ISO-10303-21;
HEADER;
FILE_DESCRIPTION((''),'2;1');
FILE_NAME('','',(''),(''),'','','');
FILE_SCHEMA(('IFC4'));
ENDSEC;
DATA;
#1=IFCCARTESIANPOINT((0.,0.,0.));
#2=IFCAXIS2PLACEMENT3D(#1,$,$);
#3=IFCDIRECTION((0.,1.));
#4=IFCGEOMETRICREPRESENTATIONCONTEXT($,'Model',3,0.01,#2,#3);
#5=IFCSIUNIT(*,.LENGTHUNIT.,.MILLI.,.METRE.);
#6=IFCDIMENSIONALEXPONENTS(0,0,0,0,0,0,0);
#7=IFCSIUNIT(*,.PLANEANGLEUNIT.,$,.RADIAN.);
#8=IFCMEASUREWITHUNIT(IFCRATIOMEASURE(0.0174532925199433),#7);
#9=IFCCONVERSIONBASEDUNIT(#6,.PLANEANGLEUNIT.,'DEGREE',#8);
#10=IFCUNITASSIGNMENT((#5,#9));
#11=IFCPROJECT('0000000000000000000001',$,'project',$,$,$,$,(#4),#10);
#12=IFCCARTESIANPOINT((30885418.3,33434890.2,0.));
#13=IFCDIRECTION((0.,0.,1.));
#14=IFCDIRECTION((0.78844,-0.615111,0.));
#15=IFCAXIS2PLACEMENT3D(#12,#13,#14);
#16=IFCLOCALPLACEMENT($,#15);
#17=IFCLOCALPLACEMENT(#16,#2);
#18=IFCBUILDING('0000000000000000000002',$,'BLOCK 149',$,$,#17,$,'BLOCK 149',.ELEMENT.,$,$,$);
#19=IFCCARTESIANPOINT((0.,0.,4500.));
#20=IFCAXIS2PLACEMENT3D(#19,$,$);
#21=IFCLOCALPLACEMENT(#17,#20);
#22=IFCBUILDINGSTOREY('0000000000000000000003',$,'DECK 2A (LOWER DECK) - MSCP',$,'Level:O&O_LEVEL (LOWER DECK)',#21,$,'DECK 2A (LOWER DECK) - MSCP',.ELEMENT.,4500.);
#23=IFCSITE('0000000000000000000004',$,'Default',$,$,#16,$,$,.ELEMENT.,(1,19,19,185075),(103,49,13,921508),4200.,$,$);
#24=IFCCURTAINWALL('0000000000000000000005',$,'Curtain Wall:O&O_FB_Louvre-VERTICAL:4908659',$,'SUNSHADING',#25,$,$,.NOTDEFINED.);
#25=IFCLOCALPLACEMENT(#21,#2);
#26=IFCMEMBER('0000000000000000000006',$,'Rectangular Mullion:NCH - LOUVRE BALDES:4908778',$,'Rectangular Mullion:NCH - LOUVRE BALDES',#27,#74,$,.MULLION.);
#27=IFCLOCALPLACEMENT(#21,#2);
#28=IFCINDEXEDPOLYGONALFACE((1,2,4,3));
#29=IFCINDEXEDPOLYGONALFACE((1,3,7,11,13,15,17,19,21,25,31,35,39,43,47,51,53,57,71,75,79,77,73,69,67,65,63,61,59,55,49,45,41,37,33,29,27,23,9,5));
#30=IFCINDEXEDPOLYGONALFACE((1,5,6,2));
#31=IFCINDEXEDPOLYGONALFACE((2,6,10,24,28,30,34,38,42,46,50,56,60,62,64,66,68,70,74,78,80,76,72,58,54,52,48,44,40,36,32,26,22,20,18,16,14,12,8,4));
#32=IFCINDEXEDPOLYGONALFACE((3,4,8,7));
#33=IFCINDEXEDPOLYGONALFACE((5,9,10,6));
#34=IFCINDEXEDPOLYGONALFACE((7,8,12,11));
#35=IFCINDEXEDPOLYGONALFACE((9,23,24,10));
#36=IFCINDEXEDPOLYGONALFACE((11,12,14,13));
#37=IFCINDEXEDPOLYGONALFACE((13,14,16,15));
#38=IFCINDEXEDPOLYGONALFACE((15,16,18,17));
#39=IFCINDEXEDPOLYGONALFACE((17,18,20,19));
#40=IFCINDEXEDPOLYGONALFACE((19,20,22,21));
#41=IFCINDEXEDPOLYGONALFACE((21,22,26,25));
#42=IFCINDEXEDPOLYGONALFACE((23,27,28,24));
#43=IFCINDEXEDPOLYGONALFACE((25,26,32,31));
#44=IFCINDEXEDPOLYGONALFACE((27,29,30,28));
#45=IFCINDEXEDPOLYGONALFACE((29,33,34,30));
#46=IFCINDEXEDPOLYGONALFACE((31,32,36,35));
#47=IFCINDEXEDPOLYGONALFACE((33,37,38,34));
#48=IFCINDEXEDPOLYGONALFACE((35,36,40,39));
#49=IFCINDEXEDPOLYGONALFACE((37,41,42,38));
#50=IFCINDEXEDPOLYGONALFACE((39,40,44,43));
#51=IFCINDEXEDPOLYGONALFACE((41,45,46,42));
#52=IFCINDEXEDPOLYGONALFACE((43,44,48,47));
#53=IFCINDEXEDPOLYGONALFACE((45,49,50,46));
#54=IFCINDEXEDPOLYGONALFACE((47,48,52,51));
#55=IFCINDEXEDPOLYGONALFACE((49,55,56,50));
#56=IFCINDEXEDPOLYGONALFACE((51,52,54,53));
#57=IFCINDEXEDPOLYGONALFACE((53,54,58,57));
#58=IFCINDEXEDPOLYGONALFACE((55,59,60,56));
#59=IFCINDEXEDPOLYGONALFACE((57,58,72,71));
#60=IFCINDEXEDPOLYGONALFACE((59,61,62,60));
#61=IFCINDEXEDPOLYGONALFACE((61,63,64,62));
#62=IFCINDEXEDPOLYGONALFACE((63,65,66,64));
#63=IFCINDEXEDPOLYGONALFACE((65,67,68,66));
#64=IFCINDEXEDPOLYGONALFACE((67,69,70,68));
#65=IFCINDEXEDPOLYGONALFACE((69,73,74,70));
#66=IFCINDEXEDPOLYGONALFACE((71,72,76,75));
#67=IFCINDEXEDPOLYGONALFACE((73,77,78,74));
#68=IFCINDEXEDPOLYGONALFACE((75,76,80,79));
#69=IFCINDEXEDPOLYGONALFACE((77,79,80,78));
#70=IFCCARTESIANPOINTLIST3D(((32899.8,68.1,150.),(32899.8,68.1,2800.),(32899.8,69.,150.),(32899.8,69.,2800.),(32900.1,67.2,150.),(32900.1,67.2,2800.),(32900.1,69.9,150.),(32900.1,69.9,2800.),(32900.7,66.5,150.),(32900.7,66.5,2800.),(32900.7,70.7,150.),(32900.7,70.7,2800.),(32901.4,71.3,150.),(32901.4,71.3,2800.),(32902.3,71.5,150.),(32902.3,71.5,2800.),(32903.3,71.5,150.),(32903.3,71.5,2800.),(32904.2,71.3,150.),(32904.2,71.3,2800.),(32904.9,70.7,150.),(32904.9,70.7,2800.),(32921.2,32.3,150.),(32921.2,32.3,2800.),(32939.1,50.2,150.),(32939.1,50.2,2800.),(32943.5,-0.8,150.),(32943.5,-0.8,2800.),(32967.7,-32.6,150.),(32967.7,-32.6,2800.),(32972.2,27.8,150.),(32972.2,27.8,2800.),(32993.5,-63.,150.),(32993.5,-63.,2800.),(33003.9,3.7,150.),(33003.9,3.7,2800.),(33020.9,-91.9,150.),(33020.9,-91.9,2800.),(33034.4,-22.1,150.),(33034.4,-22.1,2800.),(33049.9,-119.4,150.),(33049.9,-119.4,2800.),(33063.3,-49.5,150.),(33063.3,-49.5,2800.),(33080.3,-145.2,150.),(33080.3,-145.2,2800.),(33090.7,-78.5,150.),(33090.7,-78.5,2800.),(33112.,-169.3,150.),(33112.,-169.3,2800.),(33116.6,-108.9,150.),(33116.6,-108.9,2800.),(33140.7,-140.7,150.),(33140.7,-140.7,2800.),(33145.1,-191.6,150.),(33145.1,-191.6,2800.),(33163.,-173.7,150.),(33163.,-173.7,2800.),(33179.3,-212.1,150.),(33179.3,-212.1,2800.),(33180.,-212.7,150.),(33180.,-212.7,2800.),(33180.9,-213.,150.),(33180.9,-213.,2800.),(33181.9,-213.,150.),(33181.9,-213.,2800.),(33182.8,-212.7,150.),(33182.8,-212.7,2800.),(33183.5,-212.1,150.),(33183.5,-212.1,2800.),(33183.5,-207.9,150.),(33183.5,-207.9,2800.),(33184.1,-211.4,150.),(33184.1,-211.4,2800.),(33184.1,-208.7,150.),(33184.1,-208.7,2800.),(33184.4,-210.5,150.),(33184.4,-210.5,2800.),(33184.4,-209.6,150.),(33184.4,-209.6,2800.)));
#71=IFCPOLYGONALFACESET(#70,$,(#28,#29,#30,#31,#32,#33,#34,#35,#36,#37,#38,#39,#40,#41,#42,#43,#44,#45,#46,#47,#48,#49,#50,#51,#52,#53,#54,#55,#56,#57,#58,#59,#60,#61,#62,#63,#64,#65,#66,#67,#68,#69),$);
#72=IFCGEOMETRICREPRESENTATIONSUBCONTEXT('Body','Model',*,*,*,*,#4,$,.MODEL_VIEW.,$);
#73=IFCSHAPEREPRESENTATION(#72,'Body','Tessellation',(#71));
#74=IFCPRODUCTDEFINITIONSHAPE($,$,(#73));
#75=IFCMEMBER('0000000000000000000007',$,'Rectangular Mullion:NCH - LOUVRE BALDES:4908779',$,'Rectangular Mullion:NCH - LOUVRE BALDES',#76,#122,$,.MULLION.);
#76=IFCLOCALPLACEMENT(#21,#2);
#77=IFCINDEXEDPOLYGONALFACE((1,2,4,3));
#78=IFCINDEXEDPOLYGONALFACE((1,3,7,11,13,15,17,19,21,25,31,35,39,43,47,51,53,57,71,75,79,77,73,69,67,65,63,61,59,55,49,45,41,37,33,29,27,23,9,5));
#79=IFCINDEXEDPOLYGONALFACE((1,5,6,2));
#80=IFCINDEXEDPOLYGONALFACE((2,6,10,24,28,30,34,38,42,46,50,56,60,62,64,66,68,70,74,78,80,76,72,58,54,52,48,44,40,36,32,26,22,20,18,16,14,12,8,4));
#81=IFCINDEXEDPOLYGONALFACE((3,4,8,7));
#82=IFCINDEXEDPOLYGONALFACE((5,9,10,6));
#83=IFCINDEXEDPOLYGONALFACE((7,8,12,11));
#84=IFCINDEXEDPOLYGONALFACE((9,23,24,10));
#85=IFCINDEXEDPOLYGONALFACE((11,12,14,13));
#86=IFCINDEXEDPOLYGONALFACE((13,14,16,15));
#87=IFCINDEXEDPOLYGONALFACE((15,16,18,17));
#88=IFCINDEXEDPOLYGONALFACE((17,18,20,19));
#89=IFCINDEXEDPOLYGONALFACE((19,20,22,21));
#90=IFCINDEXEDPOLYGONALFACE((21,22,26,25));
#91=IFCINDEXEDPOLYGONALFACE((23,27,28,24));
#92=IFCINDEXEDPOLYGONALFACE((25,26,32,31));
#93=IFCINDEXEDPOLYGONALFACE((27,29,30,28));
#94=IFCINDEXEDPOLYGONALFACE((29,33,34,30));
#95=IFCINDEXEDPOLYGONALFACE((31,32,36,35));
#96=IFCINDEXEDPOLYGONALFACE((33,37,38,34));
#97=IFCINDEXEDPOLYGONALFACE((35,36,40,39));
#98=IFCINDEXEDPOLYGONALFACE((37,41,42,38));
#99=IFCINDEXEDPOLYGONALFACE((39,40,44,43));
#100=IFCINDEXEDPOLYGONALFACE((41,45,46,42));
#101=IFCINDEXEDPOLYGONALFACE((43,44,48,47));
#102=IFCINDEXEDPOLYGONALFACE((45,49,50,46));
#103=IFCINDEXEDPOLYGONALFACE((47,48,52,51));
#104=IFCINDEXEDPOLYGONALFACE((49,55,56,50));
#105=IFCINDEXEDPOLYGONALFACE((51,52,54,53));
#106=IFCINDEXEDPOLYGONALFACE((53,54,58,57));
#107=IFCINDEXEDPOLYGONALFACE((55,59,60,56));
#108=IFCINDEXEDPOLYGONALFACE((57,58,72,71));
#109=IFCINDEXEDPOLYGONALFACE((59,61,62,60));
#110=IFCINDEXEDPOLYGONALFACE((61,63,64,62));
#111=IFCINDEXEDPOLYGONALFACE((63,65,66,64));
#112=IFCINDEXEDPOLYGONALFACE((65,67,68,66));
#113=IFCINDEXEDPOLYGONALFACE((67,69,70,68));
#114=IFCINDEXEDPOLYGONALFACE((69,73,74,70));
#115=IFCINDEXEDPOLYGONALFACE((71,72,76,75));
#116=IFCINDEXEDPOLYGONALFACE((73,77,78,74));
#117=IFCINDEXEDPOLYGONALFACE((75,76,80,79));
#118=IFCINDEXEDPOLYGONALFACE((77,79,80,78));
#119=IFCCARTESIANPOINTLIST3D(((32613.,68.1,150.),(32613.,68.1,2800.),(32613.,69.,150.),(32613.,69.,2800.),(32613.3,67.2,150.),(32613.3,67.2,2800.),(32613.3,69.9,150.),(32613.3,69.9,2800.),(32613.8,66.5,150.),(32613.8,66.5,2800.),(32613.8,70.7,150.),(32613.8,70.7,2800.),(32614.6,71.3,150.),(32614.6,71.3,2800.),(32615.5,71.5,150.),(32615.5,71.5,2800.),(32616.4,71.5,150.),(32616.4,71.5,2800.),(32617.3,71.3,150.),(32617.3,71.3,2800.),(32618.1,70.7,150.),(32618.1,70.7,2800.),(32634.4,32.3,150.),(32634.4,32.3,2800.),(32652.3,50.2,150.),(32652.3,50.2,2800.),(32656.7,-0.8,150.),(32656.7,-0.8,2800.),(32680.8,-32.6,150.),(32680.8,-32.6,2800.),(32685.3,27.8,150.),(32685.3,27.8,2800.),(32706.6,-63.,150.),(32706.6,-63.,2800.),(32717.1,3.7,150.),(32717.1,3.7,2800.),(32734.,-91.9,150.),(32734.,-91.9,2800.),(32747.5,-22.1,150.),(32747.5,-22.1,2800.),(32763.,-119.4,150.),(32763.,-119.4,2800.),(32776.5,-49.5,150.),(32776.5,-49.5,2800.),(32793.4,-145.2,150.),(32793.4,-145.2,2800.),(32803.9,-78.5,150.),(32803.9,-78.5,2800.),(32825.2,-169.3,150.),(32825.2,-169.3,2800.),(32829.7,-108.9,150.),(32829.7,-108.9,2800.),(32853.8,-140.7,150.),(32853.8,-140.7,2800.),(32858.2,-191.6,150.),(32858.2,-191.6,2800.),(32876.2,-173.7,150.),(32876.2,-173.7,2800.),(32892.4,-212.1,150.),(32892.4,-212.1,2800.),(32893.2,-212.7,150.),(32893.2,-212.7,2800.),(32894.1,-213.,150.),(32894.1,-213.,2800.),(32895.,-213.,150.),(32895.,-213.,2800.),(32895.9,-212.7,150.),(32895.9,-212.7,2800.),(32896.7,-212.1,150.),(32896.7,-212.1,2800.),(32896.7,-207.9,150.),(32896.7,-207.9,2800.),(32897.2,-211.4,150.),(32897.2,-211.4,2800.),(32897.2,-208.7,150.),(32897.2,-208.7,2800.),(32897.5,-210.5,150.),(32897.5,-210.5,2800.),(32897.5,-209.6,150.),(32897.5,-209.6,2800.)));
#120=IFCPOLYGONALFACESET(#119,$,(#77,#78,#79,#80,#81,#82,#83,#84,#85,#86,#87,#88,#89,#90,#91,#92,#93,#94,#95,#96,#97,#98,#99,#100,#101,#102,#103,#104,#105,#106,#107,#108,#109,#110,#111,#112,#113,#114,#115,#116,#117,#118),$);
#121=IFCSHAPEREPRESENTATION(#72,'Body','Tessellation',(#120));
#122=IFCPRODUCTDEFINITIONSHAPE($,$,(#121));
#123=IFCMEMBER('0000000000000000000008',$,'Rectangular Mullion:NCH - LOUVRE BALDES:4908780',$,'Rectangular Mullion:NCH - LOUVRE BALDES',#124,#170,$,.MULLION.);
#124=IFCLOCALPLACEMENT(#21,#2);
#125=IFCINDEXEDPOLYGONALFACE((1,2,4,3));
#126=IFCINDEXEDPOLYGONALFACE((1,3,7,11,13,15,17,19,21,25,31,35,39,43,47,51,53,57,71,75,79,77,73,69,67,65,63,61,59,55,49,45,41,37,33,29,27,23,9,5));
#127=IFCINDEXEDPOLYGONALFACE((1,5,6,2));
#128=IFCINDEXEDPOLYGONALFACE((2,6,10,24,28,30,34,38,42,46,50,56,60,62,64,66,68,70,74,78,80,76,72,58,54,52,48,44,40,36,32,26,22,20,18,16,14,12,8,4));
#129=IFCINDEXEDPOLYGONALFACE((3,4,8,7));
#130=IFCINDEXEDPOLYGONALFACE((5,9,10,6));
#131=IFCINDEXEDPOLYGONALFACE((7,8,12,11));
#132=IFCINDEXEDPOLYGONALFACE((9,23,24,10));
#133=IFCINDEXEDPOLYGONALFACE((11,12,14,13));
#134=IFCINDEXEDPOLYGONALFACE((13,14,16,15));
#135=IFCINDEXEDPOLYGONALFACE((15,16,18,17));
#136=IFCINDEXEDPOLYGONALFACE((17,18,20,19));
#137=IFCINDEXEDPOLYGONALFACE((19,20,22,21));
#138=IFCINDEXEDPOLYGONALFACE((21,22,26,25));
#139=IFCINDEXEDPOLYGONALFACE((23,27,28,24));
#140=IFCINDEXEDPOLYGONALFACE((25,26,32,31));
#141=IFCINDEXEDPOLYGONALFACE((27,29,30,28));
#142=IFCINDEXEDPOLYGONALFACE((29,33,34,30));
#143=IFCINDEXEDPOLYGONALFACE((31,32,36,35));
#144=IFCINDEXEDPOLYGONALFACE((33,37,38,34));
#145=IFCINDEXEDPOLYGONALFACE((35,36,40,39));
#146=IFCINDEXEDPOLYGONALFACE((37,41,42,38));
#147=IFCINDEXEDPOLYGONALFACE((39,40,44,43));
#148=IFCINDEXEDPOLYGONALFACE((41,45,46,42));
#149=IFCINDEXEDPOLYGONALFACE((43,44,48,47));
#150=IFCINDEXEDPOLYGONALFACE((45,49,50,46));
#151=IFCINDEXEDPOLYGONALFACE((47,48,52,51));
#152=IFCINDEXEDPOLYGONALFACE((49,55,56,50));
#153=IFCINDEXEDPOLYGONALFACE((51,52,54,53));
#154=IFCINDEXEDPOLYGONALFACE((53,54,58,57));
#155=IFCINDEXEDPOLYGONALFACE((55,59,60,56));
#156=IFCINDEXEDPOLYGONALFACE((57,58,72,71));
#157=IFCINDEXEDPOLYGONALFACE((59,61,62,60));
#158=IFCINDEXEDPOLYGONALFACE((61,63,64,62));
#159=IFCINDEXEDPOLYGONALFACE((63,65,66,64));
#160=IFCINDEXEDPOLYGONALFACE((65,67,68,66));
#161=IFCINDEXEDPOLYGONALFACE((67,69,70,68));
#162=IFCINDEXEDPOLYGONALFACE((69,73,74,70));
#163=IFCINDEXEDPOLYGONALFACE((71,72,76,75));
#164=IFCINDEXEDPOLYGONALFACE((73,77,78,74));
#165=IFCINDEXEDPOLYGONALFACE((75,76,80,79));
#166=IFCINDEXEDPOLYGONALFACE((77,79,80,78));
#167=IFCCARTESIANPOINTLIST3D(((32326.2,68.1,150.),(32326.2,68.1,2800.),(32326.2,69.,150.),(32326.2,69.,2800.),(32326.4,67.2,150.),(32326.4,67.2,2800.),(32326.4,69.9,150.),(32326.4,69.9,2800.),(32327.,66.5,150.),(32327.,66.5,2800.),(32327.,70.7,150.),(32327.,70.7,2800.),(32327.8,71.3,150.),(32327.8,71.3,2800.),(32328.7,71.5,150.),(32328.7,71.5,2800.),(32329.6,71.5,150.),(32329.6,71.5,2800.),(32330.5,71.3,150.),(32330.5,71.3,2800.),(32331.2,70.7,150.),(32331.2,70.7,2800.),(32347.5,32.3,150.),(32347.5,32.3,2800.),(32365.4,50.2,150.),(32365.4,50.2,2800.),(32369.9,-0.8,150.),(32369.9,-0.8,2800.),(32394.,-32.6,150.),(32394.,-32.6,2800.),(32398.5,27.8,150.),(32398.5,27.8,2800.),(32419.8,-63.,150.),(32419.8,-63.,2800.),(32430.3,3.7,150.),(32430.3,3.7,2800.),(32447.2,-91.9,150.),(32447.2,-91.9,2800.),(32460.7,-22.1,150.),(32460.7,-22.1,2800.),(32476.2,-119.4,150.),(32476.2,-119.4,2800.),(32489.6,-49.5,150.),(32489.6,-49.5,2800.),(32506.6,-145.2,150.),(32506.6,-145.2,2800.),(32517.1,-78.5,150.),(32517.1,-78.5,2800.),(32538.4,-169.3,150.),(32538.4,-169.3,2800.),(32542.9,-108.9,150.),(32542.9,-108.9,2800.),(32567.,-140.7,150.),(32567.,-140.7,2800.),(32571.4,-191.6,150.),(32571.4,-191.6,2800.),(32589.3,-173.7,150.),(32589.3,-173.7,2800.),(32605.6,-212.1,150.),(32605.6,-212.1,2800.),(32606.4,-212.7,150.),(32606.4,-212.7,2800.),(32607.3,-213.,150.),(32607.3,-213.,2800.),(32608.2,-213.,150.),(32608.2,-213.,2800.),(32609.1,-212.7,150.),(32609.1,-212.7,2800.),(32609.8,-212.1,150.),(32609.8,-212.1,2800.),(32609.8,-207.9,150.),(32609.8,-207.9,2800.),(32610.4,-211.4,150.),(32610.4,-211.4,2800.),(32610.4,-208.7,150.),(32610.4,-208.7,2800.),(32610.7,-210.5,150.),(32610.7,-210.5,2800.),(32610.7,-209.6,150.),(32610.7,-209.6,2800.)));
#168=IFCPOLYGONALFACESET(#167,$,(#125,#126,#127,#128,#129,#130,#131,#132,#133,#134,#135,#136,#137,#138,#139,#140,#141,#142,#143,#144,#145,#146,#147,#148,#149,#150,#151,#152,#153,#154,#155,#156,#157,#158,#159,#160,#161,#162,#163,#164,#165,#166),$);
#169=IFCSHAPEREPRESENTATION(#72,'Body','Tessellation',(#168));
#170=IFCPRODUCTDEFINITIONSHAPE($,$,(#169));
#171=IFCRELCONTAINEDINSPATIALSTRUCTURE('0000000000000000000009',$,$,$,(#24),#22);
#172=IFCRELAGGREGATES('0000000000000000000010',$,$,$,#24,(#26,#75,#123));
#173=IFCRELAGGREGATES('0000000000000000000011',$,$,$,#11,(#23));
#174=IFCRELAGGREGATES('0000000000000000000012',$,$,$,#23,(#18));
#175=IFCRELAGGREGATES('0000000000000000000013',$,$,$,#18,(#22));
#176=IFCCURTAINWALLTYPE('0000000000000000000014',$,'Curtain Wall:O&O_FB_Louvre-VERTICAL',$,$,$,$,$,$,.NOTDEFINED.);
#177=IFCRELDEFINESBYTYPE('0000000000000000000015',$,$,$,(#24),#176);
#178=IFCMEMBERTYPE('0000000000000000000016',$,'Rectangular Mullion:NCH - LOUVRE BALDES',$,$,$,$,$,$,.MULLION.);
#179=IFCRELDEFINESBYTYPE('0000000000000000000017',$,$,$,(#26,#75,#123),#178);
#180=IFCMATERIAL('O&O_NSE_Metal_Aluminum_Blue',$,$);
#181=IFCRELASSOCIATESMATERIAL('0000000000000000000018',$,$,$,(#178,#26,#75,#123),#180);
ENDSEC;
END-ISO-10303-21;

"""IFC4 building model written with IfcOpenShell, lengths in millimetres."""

from ifc_helpers import new_model, entity, si_unit, converted_unit, direction, frame, origin, place, context, subcontext, project, spatial, indexed_curve, outline, extrude, source, transform, mapped, material, type_object, type_shapes, element, aggregate, save


model = new_model("IFC4")

# Units and contexts
model_context = context("Model", 3, precision=0.01, world=origin(), true_north=direction((0.0, 1.0)))
body_context = subcontext(model_context, "Body", "Model", "MODEL_VIEW")
ifc_project = project(units=[si_unit("LENGTHUNIT", "METRE", prefix="MILLI"), converted_unit("PLANEANGLEUNIT", "DEGREE", entity("IfcRatioMeasure", 0.0174532925199433), si_unit("PLANEANGLEUNIT", "RADIAN"), dimensions=[0, 0, 0, 0, 0, 0, 0])], contexts=[model_context])

# Site, building, storey
site_placement = place(None, frame((30885418.3, 33434890.2, 0.0), z_axis=(0.0, 0.0, 1.0), x_axis=(0.78844, -0.615111, 0.0)))
site = spatial("IfcSite", under=ifc_project, at=site_placement, Name="Default", CompositionType="ELEMENT", RefLatitude=(1, 19, 19, 185075), RefLongitude=(103, 49, 13, 921508), RefElevation=4200.0)
building_placement = place(site_placement, origin())
building = spatial("IfcBuilding", under=site, at=building_placement, Name="BLOCK 149", LongName="BLOCK 149", CompositionType="ELEMENT")
storey_placement = place(building_placement, frame((0.0, 0.0, 4500.0)))
storey = spatial("IfcBuildingStorey", under=building, at=storey_placement, Name="DECK 2A (LOWER DECK) - MSCP", ObjectType="Level:O&O_LEVEL (LOWER DECK)", LongName="DECK 2A (LOWER DECK) - MSCP", CompositionType="ELEMENT", Elevation=4500.0)

# Curtain wall, members
curtain_wall_type = type_object("IfcCurtainWallType", Name="Curtain Wall:O&O_FB_Louvre-VERTICAL", PredefinedType="NOTDEFINED")
curtain_wall_placement = place(storey_placement, frame((0.0, 0.0, -4500.0)))
curtain_wall = element("IfcCurtainWall", 1, at=curtain_wall_placement, inside=storey, type_object=curtain_wall_type, Name="Curtain Wall:O&O_FB_Louvre-VERTICAL:4908659", ObjectType="SUNSHADING", PredefinedType="NOTDEFINED")
placement = place(building_placement, origin())
ifc_material_1 = material(Name="O&O_NSE_Metal_Aluminum_Blue")
member_type_1 = type_object("IfcMemberType", Name="Rectangular Mullion:NCH - LOUVRE BALDES", PredefinedType="MULLION", material=ifc_material_1)
shared_shape_1 = source(origin(), body_context, "Body", "SweptSolid", [
    extrude(outline(indexed_curve([(55.9, -188.9), (54.8, -149.1), (51.6, -109.3), (46.1, -69.8), (38.6, -30.6), (28.9, 8.1), (17.1, 46.2), (3.3, 83.6), (-12.6, 120.2), (-30.4, 155.9), (-50.1, 190.5), (-50.5, 191.4), (-51.1, 192.1), (-52.0, 192.5), (-52.9, 192.7), (-53.8, 192.6), (-54.7, 192.2), (-55.4, 191.6), (-55.8, 190.8), (-56.0, 189.9), (-55.9, 188.9), (-54.8, 149.1), (-51.6, 109.3), (-46.1, 69.8), (-38.6, 30.6), (-28.9, -8.1), (-17.1, -46.2), (-3.3, -83.6), (12.6, -120.2), (30.4, -155.9), (50.1, -190.5), (50.5, -191.4), (51.1, -192.1), (52.0, -192.5), (52.9, -192.7), (53.8, -192.6), (54.7, -192.2), (55.4, -191.6), (55.8, -190.8), (56.0, -189.9), (55.9, -188.9)], self_intersect=False)), frame((0.0, 0.0, -2650.0), z_axis=(0.0, 0.0, 1.0), x_axis=(0.490779, -0.871284, 0.0)), (0.0, 0.0, 1.0), 2650.0),
])
type_shapes(member_type_1, [shared_shape_1])
member_1_placement = place(placement, frame((33042.1, -70.7, 4650.0), z_axis=(0.0, 0.0, -1.0), x_axis=(-1.0, 0.0, 0.0)))
member_1 = element("IfcMember", 2, at=member_1_placement, type_object=member_type_1, material=ifc_material_1, Name="Rectangular Mullion:NCH - LOUVRE BALDES:4908778", ObjectType="Rectangular Mullion:NCH - LOUVRE BALDES", PredefinedType="MULLION", context=body_context, shape_type="MappedRepresentation", body=[
    mapped(shared_shape_1, transform((0.0, 0.0, 0.0), scale=1.0)),
])
member_2_placement = place(placement, frame((32755.3, -70.7, 4650.0), z_axis=(0.0, 0.0, -1.0), x_axis=(-1.0, 0.0, 0.0)))
member_2 = element("IfcMember", 3, at=member_2_placement, type_object=member_type_1, material=ifc_material_1, Name="Rectangular Mullion:NCH - LOUVRE BALDES:4908779", ObjectType="Rectangular Mullion:NCH - LOUVRE BALDES", PredefinedType="MULLION", context=body_context, shape_type="MappedRepresentation", body=[
    mapped(shared_shape_1, transform((0.0, 0.0, 0.0), scale=1.0)),
])
member_3_placement = place(placement, frame((32468.4, -70.7, 4650.0), z_axis=(0.0, 0.0, -1.0), x_axis=(-1.0, 0.0, 0.0)))
member_3 = element("IfcMember", 4, at=member_3_placement, type_object=member_type_1, material=ifc_material_1, Name="Rectangular Mullion:NCH - LOUVRE BALDES:4908780", ObjectType="Rectangular Mullion:NCH - LOUVRE BALDES", PredefinedType="MULLION", context=body_context, shape_type="MappedRepresentation", body=[
    mapped(shared_shape_1, transform((0.0, 0.0, 0.0), scale=1.0)),
])
aggregate(curtain_wall, [member_1, member_2, member_3])

save(model, "model.ifc")
